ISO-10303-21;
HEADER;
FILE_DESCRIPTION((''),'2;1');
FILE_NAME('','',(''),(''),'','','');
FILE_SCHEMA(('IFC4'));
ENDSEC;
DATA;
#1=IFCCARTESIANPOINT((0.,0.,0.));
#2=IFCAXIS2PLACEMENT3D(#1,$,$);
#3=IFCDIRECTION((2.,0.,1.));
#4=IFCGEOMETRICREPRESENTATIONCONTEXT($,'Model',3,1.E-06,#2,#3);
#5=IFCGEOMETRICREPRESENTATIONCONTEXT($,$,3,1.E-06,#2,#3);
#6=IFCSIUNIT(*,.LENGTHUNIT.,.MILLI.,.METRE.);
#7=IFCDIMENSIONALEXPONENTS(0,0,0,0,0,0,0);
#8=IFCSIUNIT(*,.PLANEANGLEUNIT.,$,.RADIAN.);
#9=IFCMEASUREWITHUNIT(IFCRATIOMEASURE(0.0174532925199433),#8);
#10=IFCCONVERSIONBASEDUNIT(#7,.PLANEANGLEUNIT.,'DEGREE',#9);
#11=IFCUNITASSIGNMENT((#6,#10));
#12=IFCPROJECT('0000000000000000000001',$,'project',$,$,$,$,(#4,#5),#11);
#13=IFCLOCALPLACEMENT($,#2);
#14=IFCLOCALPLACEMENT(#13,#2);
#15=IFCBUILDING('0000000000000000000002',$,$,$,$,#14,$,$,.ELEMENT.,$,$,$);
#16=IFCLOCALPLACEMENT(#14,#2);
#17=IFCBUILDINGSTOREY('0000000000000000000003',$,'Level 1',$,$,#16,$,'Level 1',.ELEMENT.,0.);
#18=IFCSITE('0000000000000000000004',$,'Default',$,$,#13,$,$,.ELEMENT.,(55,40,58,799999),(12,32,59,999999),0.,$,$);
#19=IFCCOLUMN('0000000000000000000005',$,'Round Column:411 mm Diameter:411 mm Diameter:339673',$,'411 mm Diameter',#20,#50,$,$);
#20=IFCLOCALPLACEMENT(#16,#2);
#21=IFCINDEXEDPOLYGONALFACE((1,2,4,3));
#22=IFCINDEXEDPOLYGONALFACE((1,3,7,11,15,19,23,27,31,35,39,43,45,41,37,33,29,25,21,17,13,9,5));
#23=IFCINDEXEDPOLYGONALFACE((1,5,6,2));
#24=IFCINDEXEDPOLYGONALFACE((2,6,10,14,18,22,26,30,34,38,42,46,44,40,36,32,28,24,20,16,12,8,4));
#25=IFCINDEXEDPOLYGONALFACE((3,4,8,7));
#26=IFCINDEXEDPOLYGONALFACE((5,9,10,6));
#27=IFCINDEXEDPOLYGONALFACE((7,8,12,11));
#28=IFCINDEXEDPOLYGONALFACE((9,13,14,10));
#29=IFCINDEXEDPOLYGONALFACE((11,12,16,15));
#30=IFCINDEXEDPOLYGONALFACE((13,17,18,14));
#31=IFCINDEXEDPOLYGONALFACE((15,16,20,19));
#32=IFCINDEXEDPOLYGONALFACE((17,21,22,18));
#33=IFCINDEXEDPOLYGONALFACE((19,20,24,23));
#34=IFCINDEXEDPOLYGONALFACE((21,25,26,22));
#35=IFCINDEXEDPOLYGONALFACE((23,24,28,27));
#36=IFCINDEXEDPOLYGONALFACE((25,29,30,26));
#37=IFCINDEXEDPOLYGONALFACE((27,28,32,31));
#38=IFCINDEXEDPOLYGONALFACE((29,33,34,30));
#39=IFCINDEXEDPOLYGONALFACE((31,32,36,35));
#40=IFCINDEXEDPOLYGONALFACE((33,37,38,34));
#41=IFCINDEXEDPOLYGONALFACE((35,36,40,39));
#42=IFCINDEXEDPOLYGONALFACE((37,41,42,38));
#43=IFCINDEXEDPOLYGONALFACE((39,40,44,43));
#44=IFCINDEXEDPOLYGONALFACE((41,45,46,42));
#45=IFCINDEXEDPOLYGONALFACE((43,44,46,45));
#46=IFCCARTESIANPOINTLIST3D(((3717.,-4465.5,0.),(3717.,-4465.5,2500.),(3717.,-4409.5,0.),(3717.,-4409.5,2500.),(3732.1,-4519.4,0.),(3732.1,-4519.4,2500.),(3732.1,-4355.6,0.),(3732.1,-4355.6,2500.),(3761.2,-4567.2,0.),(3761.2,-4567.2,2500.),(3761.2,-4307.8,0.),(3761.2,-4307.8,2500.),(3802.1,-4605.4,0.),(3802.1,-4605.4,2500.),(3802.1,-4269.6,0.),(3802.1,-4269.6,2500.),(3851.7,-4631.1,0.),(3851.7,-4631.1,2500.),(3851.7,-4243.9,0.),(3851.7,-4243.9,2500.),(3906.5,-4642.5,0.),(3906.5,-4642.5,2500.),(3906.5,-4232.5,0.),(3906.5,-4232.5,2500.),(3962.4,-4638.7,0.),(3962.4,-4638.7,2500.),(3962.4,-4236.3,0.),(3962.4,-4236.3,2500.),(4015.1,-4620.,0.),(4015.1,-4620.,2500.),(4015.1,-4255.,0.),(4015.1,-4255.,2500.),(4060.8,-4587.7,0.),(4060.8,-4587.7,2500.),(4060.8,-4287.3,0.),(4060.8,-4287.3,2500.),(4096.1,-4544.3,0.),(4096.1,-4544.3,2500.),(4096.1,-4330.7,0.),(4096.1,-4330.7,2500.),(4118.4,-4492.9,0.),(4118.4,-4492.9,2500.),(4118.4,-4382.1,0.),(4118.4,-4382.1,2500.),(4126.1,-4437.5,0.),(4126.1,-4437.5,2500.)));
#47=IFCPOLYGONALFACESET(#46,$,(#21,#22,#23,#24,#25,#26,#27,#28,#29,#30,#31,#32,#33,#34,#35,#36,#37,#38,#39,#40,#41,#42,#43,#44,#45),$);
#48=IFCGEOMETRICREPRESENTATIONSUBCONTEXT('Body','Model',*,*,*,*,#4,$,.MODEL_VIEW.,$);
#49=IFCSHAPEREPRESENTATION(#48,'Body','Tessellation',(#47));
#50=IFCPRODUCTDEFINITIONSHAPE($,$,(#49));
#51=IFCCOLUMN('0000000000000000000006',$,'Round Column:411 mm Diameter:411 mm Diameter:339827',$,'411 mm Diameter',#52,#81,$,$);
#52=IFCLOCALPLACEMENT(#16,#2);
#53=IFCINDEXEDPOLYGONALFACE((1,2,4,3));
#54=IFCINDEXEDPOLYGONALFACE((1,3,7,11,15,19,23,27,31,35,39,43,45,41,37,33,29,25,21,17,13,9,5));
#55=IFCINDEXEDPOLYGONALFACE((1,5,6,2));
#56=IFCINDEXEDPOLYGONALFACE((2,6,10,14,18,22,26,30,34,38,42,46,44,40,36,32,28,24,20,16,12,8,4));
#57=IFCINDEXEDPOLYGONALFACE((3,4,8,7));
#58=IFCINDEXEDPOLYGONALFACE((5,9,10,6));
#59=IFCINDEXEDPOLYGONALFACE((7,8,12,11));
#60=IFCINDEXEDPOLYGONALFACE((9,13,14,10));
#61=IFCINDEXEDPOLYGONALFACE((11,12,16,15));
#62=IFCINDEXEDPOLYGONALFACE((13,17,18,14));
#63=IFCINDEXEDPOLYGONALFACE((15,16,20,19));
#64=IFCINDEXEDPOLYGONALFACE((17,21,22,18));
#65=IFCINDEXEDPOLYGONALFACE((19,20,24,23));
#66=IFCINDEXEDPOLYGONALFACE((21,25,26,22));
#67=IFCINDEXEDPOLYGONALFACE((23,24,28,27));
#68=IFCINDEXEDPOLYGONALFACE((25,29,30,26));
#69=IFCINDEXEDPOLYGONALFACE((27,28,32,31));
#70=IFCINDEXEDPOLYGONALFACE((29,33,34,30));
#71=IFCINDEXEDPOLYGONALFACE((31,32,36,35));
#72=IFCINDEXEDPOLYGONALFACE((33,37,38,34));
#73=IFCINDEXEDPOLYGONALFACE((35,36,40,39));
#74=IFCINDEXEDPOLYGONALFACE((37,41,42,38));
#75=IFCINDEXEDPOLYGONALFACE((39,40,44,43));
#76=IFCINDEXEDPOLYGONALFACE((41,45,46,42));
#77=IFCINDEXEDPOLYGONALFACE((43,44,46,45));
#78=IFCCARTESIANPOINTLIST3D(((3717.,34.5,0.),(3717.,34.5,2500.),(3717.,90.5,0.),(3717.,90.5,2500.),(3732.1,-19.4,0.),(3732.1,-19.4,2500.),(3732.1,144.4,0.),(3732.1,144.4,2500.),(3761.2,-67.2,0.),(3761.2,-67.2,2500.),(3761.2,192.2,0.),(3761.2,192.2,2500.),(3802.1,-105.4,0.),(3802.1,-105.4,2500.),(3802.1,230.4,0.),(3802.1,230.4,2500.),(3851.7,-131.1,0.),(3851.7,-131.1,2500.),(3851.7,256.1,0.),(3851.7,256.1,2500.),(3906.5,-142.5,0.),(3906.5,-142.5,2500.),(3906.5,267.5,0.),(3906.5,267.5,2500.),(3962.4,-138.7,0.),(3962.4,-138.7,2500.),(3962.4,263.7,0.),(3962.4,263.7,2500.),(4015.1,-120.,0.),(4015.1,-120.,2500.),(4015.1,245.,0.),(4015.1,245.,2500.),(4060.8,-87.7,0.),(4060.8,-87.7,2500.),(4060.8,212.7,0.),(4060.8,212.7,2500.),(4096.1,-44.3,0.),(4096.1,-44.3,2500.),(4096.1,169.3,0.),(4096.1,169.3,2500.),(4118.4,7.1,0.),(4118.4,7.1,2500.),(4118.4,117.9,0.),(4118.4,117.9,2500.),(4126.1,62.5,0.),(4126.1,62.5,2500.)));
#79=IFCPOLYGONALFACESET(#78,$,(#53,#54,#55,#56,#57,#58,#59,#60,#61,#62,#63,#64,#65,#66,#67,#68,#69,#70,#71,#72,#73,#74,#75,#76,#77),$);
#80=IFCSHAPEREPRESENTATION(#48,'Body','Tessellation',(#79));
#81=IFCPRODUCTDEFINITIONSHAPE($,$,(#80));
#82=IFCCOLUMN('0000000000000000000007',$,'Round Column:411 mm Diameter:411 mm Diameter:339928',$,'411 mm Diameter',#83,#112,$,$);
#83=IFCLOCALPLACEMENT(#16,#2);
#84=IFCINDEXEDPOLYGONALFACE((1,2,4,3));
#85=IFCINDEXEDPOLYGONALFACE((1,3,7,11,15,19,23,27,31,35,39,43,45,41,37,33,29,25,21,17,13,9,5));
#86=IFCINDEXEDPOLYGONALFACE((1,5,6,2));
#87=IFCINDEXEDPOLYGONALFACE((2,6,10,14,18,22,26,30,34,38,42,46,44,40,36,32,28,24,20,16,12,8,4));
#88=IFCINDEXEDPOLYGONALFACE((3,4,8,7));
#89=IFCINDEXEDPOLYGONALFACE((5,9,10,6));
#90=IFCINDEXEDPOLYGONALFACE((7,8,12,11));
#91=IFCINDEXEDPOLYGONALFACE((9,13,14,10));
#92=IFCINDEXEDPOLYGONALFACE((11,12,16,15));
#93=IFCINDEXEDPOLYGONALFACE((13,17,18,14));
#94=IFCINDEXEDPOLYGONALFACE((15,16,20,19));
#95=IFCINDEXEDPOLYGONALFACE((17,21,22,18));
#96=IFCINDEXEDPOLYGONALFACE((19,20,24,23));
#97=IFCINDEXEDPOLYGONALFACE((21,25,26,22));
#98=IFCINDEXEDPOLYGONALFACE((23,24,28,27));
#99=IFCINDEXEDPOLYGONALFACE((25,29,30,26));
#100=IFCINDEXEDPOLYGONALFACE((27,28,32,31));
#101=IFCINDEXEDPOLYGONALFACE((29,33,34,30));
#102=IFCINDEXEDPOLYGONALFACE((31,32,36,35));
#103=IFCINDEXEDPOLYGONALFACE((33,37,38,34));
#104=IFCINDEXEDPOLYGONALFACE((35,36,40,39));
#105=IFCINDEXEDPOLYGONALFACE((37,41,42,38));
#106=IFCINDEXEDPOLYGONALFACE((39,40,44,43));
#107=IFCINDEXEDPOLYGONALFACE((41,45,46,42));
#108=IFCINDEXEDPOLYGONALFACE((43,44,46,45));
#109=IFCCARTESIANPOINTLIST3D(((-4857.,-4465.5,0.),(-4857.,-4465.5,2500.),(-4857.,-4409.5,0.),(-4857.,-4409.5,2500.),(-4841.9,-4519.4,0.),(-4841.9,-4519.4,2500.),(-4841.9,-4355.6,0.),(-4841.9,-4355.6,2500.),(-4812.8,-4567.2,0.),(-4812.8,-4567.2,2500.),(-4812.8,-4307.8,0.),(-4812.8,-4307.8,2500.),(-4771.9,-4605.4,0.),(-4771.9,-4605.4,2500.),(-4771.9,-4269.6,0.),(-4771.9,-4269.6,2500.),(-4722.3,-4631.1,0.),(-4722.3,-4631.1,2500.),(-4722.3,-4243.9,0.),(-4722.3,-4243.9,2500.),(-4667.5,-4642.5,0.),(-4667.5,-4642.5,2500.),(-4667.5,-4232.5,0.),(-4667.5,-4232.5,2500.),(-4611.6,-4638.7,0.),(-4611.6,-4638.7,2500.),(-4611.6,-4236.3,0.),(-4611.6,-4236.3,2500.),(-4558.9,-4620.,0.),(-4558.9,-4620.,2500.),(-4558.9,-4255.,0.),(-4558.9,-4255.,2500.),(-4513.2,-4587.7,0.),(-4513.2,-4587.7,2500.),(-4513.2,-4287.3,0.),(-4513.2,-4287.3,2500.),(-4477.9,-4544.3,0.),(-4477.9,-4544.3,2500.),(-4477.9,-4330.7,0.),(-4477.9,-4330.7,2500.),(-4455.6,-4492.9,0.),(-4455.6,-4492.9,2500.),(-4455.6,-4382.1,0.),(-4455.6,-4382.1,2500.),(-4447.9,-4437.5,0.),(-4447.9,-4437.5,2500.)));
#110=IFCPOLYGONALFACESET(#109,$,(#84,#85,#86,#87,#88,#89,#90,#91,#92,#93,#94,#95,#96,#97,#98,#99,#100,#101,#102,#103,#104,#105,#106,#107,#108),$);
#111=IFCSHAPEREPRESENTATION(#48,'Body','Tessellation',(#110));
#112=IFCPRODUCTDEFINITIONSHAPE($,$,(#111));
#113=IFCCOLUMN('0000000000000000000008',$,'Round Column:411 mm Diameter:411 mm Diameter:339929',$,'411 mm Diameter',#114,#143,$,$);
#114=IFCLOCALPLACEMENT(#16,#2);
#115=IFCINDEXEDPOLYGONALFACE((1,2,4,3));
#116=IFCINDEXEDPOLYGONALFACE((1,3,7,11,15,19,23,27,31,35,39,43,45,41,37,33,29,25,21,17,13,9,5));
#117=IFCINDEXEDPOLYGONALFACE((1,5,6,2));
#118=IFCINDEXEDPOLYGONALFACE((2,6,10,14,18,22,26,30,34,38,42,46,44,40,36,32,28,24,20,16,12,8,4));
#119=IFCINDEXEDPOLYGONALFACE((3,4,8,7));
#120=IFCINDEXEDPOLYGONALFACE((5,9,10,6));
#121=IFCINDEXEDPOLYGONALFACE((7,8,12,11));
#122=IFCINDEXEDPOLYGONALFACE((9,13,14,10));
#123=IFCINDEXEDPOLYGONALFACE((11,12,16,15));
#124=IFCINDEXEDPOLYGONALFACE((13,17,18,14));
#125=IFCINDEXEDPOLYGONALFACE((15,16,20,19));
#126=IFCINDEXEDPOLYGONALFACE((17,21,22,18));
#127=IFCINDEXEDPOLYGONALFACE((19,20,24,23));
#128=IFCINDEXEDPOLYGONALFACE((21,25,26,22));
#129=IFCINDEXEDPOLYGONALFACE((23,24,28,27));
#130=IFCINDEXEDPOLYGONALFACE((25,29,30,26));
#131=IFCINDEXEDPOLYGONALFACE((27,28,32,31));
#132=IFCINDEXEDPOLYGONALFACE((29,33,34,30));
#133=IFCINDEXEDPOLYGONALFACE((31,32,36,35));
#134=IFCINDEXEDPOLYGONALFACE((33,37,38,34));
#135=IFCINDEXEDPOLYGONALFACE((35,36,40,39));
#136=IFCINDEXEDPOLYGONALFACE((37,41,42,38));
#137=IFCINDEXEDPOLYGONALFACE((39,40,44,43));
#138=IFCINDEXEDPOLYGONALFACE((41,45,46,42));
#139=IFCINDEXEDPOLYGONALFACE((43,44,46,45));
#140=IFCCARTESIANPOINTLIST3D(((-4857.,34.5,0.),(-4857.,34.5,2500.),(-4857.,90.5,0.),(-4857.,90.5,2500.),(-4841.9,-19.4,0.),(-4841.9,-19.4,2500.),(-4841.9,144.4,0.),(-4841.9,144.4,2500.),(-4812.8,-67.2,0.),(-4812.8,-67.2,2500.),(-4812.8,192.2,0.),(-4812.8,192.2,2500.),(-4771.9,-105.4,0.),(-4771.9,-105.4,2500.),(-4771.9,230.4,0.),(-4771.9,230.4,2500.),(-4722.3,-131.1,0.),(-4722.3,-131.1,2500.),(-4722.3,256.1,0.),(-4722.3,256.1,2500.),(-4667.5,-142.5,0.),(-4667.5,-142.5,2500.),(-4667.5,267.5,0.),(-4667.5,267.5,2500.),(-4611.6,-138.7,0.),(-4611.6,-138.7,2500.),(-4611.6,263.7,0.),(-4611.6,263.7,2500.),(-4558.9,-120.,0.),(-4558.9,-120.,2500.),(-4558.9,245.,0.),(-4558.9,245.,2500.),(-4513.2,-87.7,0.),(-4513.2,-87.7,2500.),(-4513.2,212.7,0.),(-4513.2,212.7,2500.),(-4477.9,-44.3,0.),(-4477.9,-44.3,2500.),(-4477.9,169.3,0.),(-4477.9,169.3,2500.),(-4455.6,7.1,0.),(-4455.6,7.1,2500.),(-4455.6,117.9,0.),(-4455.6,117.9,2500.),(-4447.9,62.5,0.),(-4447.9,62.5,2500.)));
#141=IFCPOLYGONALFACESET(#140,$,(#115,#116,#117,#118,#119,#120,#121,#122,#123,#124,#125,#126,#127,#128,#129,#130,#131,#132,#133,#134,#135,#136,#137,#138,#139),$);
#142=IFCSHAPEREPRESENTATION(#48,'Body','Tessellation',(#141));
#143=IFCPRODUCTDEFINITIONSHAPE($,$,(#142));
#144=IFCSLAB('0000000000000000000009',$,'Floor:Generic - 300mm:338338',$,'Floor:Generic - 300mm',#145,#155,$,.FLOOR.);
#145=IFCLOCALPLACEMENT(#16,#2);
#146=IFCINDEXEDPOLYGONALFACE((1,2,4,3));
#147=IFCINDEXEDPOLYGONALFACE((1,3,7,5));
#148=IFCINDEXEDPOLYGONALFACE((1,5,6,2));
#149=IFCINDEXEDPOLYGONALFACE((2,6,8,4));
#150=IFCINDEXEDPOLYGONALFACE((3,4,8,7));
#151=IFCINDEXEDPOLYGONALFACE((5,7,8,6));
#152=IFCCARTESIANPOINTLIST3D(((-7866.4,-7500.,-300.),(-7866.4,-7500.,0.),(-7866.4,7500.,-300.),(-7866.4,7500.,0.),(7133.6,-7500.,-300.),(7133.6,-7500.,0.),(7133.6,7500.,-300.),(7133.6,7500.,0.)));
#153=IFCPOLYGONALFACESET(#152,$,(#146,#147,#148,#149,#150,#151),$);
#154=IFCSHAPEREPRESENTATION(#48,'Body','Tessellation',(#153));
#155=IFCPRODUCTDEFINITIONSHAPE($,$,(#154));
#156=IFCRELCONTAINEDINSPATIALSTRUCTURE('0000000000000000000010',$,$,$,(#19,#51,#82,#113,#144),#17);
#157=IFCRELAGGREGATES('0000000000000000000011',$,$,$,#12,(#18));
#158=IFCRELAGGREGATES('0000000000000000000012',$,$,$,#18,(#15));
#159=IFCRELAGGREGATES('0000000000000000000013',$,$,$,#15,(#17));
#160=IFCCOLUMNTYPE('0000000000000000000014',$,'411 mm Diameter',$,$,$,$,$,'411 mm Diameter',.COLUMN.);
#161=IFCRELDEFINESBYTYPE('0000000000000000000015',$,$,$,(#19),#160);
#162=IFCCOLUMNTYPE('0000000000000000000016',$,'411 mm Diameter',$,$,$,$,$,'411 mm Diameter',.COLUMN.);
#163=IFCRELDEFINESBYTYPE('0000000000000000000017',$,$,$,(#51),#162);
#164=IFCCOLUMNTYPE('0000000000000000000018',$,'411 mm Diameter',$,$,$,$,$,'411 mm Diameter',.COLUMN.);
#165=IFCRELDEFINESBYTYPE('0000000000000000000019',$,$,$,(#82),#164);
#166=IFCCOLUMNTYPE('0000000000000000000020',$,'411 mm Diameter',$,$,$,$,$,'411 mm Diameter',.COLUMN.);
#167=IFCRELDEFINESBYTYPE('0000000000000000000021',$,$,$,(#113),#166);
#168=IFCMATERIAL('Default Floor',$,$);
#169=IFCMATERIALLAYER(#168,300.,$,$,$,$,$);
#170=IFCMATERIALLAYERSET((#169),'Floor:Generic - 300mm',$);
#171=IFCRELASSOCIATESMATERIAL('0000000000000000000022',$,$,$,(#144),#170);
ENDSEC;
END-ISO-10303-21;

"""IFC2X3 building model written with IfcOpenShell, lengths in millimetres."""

from ifc_helpers import new_model, entity, si_unit, converted_unit, direction, frame, frame_2d, origin, origin_2d_with_axis, place, context, subcontext, project, spatial, rectangle, circle, extrude, source, transform, mapped, material, layer, layer_set, layer_usage, type_object, type_shapes, element, save


model = new_model("IFC2X3")

# Units and contexts
model_context = context("Model", 3, precision=1e-06, world=origin(), true_north=direction((2.0, 0.0, 1.0)))
context_of_model = context(None, 3, precision=1e-06, world=origin(), true_north=direction((2.0, 0.0, 1.0)))
body_context = subcontext(model_context, "Body", "Model", "MODEL_VIEW")
ifc_project = project(units=[si_unit("LENGTHUNIT", "METRE", prefix="MILLI"), converted_unit("PLANEANGLEUNIT", "DEGREE", entity("IfcRatioMeasure", 0.0174532925199433), si_unit("PLANEANGLEUNIT", "RADIAN"), dimensions=[0, 0, 0, 0, 0, 0, 0])], contexts=[model_context, context_of_model])

# Site, building, storey
site_placement = place(None, origin())
site = spatial("IfcSite", under=ifc_project, at=site_placement, Name="Default", CompositionType="ELEMENT", RefLatitude=(55, 40, 58, 799999), RefLongitude=(12, 32, 59, 999999), RefElevation=0.0)
building_placement = place(site_placement, origin())
building = spatial("IfcBuilding", under=site, at=building_placement, CompositionType="ELEMENT")
storey_placement = place(building_placement, origin())
storey = spatial("IfcBuildingStorey", under=building, at=storey_placement, Name="Level 1", LongName="Level 1", CompositionType="ELEMENT", Elevation=0.0)

# Columns
column_type_1 = type_object("IfcColumnType", Name="411 mm Diameter", ElementType="411 mm Diameter", PredefinedType="COLUMN")
shared_shape_1 = source(origin(), body_context, "Body", "SweptSolid", [
    extrude(circle(Radius=205.5, at=frame_2d((3920.6, -4437.5), x_axis=(1.0, 0.0))), origin(), (0.0, 0.0, 1.0), 2500.0),
])
type_shapes(column_type_1, [shared_shape_1])
column_1_placement = place(storey_placement, origin())
element("IfcColumn", 1, at=column_1_placement, inside=storey, type_object=column_type_1, Name="Round Column:411 mm Diameter:411 mm Diameter:339673", ObjectType="411 mm Diameter", context=body_context, shape_type="MappedRepresentation", body=[
    mapped(shared_shape_1, transform((0.0, 0.0, 0.0), scale=1.0)),
])
column_type_2 = type_object("IfcColumnType", Name="411 mm Diameter", ElementType="411 mm Diameter", PredefinedType="COLUMN")
shared_shape_2 = source(origin(), body_context, "Body", "SweptSolid", [
    extrude(circle(Radius=205.5, at=frame_2d((3920.6, 62.5), x_axis=(1.0, 0.0))), origin(), (0.0, 0.0, 1.0), 2500.0),
])
type_shapes(column_type_2, [shared_shape_2])
column_2_placement = place(storey_placement, origin())
element("IfcColumn", 2, at=column_2_placement, inside=storey, type_object=column_type_2, Name="Round Column:411 mm Diameter:411 mm Diameter:339827", ObjectType="411 mm Diameter", context=body_context, shape_type="MappedRepresentation", body=[
    mapped(shared_shape_2, transform((0.0, 0.0, 0.0), scale=1.0)),
])
column_type_3 = type_object("IfcColumnType", Name="411 mm Diameter", ElementType="411 mm Diameter", PredefinedType="COLUMN")
shared_shape_3 = source(origin(), body_context, "Body", "SweptSolid", [
    extrude(circle(Radius=205.5, at=frame_2d((-4653.4, -4437.5), x_axis=(1.0, 0.0))), origin(), (0.0, 0.0, 1.0), 2500.0),
])
type_shapes(column_type_3, [shared_shape_3])
column_3_placement = place(storey_placement, origin())
element("IfcColumn", 3, at=column_3_placement, inside=storey, type_object=column_type_3, Name="Round Column:411 mm Diameter:411 mm Diameter:339928", ObjectType="411 mm Diameter", context=body_context, shape_type="MappedRepresentation", body=[
    mapped(shared_shape_3, transform((0.0, 0.0, 0.0), scale=1.0)),
])
column_type_4 = type_object("IfcColumnType", Name="411 mm Diameter", ElementType="411 mm Diameter", PredefinedType="COLUMN")
shared_shape_4 = source(origin(), body_context, "Body", "SweptSolid", [
    extrude(circle(Radius=205.5, at=frame_2d((-4653.4, 62.5), x_axis=(1.0, 0.0))), origin(), (0.0, 0.0, 1.0), 2500.0),
])
type_shapes(column_type_4, [shared_shape_4])
column_4_placement = place(storey_placement, origin())
element("IfcColumn", 4, at=column_4_placement, inside=storey, type_object=column_type_4, Name="Round Column:411 mm Diameter:411 mm Diameter:339929", ObjectType="411 mm Diameter", context=body_context, shape_type="MappedRepresentation", body=[
    mapped(shared_shape_4, transform((0.0, 0.0, 0.0), scale=1.0)),
])

# Slab
ifc_material = material(Name="Default Floor")
ifc_layer = layer(ifc_material, 300.0)
ifc_layer_set = layer_set([ifc_layer], Name="Floor:Generic - 300mm")
ifc_layer_usage = layer_usage(ifc_layer_set, "AXIS3", "POSITIVE", 0.0)
slab_placement = place(storey_placement, origin())
element("IfcSlab", 5, at=slab_placement, inside=storey, material=ifc_layer_usage, Name="Floor:Generic - 300mm:338338", ObjectType="Floor:Generic - 300mm", PredefinedType="FLOOR", context=body_context, shape_type="SweptSolid", body=[
    extrude(rectangle(XDim=15000.0, YDim=15000.0, at=origin_2d_with_axis()), frame((-366.4, 0.0, 0.0), z_axis=(0.0, 0.0, -1.0), x_axis=(-1.0, 0.0, 0.0)), (0.0, 0.0, 1.0), 300.0),
])

save(model, "model.ifc")
